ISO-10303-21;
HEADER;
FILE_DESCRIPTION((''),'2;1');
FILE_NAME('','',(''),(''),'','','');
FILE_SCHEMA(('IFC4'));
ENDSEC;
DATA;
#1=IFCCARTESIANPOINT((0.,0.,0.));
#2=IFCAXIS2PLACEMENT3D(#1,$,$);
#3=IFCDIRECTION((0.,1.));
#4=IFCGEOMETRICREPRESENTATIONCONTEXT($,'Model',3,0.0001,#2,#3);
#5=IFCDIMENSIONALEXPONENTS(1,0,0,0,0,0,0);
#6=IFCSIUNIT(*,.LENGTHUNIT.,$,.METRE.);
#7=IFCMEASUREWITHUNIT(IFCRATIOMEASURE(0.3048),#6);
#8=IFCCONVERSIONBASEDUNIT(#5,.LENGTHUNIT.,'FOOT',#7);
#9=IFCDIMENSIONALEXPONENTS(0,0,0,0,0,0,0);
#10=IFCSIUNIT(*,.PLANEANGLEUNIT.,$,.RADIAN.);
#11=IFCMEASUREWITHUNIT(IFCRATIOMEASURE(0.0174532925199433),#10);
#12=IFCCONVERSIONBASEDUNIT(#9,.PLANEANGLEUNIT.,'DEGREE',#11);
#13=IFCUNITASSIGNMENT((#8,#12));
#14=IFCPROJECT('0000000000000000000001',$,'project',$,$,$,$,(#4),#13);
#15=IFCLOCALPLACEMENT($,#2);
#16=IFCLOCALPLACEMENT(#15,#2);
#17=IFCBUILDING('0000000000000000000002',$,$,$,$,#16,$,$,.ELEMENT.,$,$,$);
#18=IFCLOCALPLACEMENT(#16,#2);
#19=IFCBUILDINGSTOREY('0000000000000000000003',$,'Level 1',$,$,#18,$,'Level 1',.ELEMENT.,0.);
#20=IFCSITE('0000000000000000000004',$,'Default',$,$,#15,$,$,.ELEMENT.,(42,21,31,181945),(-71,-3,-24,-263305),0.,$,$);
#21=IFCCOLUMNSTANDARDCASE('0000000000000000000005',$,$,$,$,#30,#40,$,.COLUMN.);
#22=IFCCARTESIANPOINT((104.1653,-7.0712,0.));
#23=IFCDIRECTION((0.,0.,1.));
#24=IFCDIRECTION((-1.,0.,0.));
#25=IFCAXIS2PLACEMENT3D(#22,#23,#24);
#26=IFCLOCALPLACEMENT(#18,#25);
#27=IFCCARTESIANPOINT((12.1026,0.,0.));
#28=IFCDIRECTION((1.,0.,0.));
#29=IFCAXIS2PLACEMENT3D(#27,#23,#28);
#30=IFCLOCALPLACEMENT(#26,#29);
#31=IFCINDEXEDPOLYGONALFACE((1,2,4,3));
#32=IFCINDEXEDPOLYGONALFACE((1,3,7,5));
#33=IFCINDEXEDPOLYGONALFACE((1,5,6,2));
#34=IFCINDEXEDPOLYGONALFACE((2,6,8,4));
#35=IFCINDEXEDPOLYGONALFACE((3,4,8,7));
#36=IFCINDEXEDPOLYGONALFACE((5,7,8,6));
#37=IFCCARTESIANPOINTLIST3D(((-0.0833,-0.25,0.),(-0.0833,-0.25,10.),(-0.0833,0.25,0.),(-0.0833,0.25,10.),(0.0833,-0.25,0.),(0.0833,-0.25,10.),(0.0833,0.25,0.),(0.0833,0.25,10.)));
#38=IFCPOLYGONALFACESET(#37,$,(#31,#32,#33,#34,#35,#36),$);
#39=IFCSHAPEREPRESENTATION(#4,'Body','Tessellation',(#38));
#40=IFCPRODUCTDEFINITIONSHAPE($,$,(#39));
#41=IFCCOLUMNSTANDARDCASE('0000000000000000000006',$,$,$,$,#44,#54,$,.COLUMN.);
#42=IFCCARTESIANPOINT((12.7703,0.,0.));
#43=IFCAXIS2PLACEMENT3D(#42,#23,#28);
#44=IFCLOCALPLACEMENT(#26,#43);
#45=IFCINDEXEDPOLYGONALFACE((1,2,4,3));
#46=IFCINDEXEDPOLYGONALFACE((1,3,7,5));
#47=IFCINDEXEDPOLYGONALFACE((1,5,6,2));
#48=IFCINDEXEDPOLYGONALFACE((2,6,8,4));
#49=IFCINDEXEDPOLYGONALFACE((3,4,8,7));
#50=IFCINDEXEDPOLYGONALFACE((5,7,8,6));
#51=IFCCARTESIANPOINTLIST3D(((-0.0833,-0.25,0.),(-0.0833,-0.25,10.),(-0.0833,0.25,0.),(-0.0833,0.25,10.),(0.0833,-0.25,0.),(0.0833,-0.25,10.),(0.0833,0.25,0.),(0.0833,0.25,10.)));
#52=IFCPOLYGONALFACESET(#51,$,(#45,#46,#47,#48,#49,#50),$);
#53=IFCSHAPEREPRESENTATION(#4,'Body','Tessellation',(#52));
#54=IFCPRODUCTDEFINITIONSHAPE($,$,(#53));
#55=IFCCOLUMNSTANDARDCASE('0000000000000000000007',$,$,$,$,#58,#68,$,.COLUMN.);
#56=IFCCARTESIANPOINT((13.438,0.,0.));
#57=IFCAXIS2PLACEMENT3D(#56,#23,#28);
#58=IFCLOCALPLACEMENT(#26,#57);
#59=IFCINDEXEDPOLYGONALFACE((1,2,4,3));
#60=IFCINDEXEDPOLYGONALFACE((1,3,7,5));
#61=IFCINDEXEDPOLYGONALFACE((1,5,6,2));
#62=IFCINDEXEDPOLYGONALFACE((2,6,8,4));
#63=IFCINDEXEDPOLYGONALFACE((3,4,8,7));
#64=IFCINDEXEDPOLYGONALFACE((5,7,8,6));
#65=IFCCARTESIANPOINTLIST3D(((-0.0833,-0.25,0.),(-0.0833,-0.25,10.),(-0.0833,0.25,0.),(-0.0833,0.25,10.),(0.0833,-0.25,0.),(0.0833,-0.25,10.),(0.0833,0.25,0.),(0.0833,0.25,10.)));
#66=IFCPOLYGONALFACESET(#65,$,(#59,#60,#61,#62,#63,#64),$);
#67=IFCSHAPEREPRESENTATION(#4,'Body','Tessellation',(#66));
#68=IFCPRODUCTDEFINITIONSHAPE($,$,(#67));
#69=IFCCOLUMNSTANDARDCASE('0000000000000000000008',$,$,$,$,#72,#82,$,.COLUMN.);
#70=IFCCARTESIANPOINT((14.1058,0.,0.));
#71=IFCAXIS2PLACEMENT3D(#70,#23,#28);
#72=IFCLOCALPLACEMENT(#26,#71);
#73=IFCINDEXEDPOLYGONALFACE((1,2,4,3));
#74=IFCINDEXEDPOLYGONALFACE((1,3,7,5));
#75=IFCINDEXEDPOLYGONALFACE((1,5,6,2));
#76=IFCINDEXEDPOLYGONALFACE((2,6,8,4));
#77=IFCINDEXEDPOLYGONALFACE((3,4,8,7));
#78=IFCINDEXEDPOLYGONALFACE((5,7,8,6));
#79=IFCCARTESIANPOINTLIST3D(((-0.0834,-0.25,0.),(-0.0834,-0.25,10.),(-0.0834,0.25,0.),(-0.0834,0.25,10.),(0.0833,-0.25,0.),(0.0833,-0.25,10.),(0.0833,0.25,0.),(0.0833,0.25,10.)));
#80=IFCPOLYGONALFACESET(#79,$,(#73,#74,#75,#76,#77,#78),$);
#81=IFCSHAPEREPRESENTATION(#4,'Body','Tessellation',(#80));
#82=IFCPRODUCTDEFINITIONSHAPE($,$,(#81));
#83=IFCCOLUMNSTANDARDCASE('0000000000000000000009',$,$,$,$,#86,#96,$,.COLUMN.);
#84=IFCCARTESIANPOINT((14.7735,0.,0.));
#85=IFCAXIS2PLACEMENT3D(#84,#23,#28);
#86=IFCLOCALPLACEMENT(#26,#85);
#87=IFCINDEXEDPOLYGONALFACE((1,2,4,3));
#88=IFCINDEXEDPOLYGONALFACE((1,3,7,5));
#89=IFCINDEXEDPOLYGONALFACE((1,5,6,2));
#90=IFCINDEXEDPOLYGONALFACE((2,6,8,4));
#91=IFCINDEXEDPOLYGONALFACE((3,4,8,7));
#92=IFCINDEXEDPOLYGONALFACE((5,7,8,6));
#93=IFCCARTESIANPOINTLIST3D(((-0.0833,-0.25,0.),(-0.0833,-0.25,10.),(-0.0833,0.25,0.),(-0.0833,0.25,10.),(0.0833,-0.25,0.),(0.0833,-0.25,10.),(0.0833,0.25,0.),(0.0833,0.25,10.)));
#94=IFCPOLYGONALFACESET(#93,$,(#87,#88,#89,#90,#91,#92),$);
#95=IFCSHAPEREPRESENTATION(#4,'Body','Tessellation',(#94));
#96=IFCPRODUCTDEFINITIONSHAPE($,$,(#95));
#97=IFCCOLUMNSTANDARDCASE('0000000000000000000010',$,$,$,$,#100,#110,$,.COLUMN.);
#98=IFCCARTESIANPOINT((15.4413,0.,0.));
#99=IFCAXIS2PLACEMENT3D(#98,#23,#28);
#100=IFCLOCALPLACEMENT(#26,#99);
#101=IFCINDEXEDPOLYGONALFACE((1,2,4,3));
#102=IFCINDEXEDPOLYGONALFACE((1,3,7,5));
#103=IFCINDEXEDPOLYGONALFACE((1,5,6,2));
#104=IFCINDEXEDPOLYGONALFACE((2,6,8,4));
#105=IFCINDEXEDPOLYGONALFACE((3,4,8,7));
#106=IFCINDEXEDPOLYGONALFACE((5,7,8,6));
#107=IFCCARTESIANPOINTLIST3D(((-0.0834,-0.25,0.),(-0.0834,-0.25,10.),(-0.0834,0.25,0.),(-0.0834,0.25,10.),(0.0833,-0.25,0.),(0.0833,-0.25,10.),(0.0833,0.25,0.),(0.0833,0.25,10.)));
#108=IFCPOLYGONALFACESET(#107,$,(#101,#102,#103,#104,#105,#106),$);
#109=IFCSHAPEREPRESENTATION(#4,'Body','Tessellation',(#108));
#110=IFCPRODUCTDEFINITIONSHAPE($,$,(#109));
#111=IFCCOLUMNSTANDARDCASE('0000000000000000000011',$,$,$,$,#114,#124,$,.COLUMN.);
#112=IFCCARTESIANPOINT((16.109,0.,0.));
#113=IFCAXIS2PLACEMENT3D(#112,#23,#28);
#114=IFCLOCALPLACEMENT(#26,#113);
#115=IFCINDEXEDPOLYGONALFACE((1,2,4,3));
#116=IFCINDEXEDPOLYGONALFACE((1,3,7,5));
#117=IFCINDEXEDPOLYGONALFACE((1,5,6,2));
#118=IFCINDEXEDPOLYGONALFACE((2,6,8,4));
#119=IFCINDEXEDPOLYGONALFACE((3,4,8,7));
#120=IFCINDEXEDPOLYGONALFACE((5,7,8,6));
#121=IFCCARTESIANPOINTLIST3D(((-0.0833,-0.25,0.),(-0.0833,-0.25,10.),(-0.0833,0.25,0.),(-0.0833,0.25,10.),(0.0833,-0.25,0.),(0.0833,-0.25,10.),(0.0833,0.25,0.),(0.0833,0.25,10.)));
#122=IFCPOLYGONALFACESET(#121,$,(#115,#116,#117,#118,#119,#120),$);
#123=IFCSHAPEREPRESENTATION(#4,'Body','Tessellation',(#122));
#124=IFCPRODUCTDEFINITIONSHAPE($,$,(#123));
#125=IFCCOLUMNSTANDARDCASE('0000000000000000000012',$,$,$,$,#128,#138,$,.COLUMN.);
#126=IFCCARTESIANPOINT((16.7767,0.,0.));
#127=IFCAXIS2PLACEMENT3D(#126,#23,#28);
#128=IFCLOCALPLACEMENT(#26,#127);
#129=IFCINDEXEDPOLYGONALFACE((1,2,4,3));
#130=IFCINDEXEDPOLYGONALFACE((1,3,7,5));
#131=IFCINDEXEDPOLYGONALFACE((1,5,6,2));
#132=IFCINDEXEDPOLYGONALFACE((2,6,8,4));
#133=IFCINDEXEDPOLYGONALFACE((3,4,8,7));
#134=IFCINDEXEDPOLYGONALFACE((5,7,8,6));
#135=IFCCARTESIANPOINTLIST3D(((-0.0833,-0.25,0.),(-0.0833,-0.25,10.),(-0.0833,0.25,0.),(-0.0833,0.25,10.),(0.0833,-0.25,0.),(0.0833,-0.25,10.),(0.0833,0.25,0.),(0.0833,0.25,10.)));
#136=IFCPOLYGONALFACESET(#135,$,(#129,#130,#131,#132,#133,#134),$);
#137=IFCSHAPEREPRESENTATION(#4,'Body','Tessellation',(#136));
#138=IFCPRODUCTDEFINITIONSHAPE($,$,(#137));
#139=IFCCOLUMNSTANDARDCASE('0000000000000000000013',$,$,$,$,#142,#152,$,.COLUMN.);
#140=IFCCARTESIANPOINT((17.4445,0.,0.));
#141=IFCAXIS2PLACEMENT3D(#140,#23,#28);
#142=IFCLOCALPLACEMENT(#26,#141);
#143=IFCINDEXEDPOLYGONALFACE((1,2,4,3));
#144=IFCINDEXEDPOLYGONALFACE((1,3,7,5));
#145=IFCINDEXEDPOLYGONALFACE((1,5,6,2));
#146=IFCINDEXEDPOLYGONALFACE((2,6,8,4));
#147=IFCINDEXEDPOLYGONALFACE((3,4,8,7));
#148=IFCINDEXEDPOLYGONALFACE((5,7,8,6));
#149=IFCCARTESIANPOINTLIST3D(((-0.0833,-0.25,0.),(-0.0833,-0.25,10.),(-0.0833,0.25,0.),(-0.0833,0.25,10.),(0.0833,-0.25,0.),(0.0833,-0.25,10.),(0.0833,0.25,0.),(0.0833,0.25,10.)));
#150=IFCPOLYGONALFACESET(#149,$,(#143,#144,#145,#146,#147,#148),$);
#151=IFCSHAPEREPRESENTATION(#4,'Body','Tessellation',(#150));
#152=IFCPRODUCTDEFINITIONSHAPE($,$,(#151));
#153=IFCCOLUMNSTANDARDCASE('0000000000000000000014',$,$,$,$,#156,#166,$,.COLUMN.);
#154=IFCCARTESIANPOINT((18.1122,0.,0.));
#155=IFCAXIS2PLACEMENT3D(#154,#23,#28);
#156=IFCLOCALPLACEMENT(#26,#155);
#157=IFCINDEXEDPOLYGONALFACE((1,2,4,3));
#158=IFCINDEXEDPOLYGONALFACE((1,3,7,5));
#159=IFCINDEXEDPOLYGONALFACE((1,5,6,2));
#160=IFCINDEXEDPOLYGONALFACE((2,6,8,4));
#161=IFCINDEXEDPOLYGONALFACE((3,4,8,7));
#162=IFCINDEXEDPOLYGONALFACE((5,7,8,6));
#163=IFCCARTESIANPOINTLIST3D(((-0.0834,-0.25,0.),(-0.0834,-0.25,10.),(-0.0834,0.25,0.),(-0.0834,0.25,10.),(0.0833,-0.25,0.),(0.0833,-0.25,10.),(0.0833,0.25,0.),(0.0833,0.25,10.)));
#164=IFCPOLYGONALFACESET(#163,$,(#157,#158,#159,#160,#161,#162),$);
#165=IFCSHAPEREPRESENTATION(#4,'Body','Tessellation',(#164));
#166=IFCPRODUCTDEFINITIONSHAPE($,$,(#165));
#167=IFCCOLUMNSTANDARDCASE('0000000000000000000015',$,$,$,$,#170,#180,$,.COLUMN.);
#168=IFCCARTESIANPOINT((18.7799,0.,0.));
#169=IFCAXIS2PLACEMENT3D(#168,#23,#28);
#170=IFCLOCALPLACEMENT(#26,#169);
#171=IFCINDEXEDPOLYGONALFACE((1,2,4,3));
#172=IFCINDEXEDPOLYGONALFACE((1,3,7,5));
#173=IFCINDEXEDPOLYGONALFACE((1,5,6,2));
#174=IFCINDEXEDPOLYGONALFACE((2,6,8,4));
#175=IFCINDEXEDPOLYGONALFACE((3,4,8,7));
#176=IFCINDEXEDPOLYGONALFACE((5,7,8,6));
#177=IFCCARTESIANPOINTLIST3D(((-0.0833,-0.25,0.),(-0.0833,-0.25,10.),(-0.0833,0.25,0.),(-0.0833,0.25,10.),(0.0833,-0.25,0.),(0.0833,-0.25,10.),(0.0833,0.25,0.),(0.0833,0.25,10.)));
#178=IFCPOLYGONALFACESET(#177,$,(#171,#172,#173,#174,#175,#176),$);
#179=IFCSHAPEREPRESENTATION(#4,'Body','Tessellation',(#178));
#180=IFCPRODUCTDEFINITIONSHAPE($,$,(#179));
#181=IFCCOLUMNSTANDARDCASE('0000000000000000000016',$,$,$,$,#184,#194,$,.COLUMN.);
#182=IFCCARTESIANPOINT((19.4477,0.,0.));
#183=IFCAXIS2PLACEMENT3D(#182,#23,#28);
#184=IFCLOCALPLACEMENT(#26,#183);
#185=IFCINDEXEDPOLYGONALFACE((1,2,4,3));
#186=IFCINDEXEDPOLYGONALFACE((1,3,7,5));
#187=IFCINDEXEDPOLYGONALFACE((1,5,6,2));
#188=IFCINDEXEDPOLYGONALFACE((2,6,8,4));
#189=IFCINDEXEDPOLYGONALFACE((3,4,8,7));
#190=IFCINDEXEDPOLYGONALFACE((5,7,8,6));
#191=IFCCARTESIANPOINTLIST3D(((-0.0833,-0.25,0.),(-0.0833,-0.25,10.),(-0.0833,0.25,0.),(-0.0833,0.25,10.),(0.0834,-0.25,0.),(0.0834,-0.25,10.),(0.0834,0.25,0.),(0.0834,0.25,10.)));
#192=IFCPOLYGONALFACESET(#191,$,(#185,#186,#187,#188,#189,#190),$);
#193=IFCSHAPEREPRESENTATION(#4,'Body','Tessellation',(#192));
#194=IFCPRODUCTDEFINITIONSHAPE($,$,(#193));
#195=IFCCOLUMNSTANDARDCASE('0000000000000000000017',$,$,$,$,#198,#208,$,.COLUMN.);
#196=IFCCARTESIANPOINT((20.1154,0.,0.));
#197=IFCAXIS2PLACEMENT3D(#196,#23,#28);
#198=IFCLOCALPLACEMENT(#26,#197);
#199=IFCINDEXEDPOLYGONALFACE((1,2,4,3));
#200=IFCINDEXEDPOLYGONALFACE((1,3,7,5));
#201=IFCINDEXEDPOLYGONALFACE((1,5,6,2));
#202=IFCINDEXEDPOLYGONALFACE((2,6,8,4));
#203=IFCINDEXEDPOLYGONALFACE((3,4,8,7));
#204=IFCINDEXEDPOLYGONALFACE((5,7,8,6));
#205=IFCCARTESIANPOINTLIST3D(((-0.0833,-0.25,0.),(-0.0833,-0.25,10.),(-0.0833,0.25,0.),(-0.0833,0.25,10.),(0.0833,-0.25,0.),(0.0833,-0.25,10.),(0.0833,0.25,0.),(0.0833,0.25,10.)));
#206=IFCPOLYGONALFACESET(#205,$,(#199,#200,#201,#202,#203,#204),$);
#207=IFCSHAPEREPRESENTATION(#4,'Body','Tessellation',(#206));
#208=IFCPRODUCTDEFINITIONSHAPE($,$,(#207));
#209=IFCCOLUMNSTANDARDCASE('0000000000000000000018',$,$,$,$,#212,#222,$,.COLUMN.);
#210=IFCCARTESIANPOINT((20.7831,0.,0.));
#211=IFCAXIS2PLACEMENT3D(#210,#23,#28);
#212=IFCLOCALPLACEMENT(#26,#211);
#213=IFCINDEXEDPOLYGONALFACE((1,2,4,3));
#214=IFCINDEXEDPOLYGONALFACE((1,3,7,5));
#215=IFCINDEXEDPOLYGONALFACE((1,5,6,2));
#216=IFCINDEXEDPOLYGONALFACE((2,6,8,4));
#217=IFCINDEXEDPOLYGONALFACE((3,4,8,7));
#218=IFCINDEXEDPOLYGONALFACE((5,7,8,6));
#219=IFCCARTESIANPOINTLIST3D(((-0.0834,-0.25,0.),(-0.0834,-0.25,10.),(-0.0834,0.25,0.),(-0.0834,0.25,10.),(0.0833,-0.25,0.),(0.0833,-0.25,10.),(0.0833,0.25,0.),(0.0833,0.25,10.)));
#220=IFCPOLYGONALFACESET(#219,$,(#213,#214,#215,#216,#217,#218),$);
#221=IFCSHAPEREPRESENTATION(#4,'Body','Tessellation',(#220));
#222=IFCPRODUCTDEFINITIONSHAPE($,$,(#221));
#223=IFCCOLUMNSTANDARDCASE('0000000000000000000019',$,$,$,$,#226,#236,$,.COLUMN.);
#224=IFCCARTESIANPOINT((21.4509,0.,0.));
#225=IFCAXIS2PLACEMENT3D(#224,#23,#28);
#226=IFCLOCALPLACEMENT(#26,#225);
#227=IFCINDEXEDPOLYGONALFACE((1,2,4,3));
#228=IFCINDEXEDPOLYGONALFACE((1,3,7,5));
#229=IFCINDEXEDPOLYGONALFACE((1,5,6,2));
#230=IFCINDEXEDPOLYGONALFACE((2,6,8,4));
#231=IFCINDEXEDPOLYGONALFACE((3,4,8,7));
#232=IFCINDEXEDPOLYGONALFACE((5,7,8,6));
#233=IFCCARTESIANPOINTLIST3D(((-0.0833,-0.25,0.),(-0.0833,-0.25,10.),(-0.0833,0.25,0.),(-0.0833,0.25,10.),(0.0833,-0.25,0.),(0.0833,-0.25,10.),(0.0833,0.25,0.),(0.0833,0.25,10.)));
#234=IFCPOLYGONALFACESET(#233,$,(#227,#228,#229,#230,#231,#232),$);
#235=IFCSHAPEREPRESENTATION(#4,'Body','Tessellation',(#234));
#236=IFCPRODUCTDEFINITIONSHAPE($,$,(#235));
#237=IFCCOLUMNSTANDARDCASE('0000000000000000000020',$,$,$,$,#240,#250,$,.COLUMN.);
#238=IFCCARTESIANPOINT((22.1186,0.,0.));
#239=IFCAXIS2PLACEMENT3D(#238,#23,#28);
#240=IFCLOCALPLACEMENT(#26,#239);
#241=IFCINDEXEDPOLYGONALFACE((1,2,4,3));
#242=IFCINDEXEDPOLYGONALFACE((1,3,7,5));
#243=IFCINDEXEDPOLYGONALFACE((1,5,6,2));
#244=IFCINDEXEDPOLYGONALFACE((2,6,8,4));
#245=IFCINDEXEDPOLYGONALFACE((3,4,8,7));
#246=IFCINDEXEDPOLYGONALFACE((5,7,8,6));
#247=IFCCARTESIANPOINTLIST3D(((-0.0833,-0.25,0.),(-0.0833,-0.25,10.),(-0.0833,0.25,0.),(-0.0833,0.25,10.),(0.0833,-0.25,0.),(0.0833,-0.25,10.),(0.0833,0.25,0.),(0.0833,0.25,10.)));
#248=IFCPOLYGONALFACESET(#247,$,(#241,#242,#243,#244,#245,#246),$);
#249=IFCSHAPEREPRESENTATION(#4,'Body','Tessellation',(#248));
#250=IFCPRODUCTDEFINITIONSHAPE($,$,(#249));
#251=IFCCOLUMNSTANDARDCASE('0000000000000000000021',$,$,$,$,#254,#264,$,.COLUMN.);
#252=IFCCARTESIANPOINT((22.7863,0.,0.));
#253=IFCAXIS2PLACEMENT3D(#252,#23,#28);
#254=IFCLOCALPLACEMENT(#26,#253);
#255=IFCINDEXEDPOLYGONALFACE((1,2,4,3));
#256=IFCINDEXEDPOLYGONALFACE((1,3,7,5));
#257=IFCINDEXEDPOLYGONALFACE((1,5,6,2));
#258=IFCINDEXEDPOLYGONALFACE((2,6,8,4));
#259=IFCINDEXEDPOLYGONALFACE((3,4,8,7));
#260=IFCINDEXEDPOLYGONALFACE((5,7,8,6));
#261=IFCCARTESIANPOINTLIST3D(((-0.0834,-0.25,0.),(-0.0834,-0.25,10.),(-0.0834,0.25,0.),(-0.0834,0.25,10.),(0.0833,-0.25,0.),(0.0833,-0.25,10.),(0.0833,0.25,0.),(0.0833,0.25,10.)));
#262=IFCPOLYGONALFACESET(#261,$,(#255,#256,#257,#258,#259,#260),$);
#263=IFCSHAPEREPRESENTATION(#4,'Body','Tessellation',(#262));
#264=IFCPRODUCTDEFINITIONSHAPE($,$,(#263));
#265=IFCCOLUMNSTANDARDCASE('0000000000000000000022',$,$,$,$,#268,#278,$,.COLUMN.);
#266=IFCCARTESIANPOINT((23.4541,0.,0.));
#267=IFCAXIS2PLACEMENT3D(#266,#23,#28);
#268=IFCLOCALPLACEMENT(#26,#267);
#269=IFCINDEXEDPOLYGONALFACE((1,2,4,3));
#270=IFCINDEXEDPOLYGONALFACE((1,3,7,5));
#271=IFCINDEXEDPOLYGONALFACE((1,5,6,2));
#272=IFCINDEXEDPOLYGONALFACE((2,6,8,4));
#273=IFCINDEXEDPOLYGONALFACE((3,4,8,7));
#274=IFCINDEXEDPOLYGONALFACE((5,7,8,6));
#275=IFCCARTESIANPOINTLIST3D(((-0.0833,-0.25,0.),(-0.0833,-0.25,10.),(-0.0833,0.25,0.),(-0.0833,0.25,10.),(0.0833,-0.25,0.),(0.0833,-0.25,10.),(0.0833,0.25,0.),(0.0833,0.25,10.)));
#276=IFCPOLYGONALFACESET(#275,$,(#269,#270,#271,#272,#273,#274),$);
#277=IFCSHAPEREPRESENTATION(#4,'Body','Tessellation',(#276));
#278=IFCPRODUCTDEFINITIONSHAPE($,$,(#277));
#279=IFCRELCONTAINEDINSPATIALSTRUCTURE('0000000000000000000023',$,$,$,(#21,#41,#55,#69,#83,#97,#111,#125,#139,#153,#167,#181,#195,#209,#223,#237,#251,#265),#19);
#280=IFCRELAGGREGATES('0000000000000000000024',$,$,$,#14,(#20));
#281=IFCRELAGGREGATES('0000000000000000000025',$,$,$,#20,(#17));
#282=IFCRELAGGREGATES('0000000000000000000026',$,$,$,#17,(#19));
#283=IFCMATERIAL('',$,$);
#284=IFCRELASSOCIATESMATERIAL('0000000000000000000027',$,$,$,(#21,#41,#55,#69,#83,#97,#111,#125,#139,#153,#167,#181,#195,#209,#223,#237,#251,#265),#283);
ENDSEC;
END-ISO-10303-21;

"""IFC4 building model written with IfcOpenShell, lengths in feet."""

from ifc_helpers import new_model, entity, si_unit, converted_unit, direction, frame, origin, place, context, project, spatial, rectangle, extrude, material, element, save


model = new_model("IFC4")

# Units and contexts
model_context = context("Model", 3, precision=0.0001, world=origin(), true_north=direction((0.0, 1.0)))
ifc_project = project(units=[converted_unit("LENGTHUNIT", "FOOT", entity("IfcRatioMeasure", 0.3048), si_unit("LENGTHUNIT", "METRE"), dimensions=[1, 0, 0, 0, 0, 0, 0]), converted_unit("PLANEANGLEUNIT", "DEGREE", entity("IfcRatioMeasure", 0.0174532925199433), si_unit("PLANEANGLEUNIT", "RADIAN"), dimensions=[0, 0, 0, 0, 0, 0, 0])], contexts=[model_context])

# Site, building, storey
site_placement = place(None, origin())
site = spatial("IfcSite", under=ifc_project, at=site_placement, Name="Default", CompositionType="ELEMENT", RefLatitude=(42, 21, 31, 181945), RefLongitude=(-71, -3, -24, -263305), RefElevation=0.0)
building_placement = place(site_placement, origin())
building = spatial("IfcBuilding", under=site, at=building_placement, CompositionType="ELEMENT")
storey_placement = place(building_placement, origin())
storey = spatial("IfcBuildingStorey", under=building, at=storey_placement, Name="Level 1", LongName="Level 1", CompositionType="ELEMENT", Elevation=0.0)

# Columns
ifc_material = material(Name="")
placement = place(storey_placement, frame((104.1653, -7.0712, 0.0), z_axis=(0.0, 0.0, 1.0), x_axis=(-1.0, 0.0, 0.0)))
for number, where, z_axis, x_axis in (
    (1, (12.1026, 0.0, 0.0), (0.0, 0.0, 1.0), (1.0, 0.0, 0.0)),
    (2, (12.7703, 0.0, 0.0), (0.0, 0.0, 1.0), (1.0, 0.0, 0.0)),
    (3, (13.438, 0.0, 0.0), (0.0, 0.0, 1.0), (1.0, 0.0, 0.0)),
    (4, (14.1058, 0.0, 0.0), (0.0, 0.0, 1.0), (1.0, 0.0, 0.0)),
    (5, (14.7735, 0.0, 0.0), (0.0, 0.0, 1.0), (1.0, 0.0, 0.0)),
    (6, (15.4413, 0.0, 0.0), (0.0, 0.0, 1.0), (1.0, 0.0, 0.0)),
    (7, (16.109, 0.0, 0.0), (0.0, 0.0, 1.0), (1.0, 0.0, 0.0)),
    (8, (16.7767, 0.0, 0.0), (0.0, 0.0, 1.0), (1.0, 0.0, 0.0)),
    (9, (17.4445, 0.0, 0.0), (0.0, 0.0, 1.0), (1.0, 0.0, 0.0)),
    (10, (18.1122, 0.0, 0.0), (0.0, 0.0, 1.0), (1.0, 0.0, 0.0)),
    (11, (18.7799, 0.0, 0.0), (0.0, 0.0, 1.0), (1.0, 0.0, 0.0)),
    (12, (19.4477, 0.0, 0.0), (0.0, 0.0, 1.0), (1.0, 0.0, 0.0)),
    (13, (20.1154, 0.0, 0.0), (0.0, 0.0, 1.0), (1.0, 0.0, 0.0)),
    (14, (20.7831, 0.0, 0.0), (0.0, 0.0, 1.0), (1.0, 0.0, 0.0)),
    (15, (21.4509, 0.0, 0.0), (0.0, 0.0, 1.0), (1.0, 0.0, 0.0)),
    (16, (22.1186, 0.0, 0.0), (0.0, 0.0, 1.0), (1.0, 0.0, 0.0)),
    (17, (22.7863, 0.0, 0.0), (0.0, 0.0, 1.0), (1.0, 0.0, 0.0)),
    (18, (23.4541, 0.0, 0.0), (0.0, 0.0, 1.0), (1.0, 0.0, 0.0)),
):
    element("IfcColumnStandardCase", number, at=place(placement, frame(where, z_axis=z_axis, x_axis=x_axis)), inside=storey, material=ifc_material, PredefinedType="COLUMN", context=model_context, shape_type="SweptSolid", body=[
        extrude(rectangle(XDim=0.1667, YDim=0.5), origin(), (0.0, 0.0, 1.0), 10.0),
    ])

save(model, "model.ifc")
